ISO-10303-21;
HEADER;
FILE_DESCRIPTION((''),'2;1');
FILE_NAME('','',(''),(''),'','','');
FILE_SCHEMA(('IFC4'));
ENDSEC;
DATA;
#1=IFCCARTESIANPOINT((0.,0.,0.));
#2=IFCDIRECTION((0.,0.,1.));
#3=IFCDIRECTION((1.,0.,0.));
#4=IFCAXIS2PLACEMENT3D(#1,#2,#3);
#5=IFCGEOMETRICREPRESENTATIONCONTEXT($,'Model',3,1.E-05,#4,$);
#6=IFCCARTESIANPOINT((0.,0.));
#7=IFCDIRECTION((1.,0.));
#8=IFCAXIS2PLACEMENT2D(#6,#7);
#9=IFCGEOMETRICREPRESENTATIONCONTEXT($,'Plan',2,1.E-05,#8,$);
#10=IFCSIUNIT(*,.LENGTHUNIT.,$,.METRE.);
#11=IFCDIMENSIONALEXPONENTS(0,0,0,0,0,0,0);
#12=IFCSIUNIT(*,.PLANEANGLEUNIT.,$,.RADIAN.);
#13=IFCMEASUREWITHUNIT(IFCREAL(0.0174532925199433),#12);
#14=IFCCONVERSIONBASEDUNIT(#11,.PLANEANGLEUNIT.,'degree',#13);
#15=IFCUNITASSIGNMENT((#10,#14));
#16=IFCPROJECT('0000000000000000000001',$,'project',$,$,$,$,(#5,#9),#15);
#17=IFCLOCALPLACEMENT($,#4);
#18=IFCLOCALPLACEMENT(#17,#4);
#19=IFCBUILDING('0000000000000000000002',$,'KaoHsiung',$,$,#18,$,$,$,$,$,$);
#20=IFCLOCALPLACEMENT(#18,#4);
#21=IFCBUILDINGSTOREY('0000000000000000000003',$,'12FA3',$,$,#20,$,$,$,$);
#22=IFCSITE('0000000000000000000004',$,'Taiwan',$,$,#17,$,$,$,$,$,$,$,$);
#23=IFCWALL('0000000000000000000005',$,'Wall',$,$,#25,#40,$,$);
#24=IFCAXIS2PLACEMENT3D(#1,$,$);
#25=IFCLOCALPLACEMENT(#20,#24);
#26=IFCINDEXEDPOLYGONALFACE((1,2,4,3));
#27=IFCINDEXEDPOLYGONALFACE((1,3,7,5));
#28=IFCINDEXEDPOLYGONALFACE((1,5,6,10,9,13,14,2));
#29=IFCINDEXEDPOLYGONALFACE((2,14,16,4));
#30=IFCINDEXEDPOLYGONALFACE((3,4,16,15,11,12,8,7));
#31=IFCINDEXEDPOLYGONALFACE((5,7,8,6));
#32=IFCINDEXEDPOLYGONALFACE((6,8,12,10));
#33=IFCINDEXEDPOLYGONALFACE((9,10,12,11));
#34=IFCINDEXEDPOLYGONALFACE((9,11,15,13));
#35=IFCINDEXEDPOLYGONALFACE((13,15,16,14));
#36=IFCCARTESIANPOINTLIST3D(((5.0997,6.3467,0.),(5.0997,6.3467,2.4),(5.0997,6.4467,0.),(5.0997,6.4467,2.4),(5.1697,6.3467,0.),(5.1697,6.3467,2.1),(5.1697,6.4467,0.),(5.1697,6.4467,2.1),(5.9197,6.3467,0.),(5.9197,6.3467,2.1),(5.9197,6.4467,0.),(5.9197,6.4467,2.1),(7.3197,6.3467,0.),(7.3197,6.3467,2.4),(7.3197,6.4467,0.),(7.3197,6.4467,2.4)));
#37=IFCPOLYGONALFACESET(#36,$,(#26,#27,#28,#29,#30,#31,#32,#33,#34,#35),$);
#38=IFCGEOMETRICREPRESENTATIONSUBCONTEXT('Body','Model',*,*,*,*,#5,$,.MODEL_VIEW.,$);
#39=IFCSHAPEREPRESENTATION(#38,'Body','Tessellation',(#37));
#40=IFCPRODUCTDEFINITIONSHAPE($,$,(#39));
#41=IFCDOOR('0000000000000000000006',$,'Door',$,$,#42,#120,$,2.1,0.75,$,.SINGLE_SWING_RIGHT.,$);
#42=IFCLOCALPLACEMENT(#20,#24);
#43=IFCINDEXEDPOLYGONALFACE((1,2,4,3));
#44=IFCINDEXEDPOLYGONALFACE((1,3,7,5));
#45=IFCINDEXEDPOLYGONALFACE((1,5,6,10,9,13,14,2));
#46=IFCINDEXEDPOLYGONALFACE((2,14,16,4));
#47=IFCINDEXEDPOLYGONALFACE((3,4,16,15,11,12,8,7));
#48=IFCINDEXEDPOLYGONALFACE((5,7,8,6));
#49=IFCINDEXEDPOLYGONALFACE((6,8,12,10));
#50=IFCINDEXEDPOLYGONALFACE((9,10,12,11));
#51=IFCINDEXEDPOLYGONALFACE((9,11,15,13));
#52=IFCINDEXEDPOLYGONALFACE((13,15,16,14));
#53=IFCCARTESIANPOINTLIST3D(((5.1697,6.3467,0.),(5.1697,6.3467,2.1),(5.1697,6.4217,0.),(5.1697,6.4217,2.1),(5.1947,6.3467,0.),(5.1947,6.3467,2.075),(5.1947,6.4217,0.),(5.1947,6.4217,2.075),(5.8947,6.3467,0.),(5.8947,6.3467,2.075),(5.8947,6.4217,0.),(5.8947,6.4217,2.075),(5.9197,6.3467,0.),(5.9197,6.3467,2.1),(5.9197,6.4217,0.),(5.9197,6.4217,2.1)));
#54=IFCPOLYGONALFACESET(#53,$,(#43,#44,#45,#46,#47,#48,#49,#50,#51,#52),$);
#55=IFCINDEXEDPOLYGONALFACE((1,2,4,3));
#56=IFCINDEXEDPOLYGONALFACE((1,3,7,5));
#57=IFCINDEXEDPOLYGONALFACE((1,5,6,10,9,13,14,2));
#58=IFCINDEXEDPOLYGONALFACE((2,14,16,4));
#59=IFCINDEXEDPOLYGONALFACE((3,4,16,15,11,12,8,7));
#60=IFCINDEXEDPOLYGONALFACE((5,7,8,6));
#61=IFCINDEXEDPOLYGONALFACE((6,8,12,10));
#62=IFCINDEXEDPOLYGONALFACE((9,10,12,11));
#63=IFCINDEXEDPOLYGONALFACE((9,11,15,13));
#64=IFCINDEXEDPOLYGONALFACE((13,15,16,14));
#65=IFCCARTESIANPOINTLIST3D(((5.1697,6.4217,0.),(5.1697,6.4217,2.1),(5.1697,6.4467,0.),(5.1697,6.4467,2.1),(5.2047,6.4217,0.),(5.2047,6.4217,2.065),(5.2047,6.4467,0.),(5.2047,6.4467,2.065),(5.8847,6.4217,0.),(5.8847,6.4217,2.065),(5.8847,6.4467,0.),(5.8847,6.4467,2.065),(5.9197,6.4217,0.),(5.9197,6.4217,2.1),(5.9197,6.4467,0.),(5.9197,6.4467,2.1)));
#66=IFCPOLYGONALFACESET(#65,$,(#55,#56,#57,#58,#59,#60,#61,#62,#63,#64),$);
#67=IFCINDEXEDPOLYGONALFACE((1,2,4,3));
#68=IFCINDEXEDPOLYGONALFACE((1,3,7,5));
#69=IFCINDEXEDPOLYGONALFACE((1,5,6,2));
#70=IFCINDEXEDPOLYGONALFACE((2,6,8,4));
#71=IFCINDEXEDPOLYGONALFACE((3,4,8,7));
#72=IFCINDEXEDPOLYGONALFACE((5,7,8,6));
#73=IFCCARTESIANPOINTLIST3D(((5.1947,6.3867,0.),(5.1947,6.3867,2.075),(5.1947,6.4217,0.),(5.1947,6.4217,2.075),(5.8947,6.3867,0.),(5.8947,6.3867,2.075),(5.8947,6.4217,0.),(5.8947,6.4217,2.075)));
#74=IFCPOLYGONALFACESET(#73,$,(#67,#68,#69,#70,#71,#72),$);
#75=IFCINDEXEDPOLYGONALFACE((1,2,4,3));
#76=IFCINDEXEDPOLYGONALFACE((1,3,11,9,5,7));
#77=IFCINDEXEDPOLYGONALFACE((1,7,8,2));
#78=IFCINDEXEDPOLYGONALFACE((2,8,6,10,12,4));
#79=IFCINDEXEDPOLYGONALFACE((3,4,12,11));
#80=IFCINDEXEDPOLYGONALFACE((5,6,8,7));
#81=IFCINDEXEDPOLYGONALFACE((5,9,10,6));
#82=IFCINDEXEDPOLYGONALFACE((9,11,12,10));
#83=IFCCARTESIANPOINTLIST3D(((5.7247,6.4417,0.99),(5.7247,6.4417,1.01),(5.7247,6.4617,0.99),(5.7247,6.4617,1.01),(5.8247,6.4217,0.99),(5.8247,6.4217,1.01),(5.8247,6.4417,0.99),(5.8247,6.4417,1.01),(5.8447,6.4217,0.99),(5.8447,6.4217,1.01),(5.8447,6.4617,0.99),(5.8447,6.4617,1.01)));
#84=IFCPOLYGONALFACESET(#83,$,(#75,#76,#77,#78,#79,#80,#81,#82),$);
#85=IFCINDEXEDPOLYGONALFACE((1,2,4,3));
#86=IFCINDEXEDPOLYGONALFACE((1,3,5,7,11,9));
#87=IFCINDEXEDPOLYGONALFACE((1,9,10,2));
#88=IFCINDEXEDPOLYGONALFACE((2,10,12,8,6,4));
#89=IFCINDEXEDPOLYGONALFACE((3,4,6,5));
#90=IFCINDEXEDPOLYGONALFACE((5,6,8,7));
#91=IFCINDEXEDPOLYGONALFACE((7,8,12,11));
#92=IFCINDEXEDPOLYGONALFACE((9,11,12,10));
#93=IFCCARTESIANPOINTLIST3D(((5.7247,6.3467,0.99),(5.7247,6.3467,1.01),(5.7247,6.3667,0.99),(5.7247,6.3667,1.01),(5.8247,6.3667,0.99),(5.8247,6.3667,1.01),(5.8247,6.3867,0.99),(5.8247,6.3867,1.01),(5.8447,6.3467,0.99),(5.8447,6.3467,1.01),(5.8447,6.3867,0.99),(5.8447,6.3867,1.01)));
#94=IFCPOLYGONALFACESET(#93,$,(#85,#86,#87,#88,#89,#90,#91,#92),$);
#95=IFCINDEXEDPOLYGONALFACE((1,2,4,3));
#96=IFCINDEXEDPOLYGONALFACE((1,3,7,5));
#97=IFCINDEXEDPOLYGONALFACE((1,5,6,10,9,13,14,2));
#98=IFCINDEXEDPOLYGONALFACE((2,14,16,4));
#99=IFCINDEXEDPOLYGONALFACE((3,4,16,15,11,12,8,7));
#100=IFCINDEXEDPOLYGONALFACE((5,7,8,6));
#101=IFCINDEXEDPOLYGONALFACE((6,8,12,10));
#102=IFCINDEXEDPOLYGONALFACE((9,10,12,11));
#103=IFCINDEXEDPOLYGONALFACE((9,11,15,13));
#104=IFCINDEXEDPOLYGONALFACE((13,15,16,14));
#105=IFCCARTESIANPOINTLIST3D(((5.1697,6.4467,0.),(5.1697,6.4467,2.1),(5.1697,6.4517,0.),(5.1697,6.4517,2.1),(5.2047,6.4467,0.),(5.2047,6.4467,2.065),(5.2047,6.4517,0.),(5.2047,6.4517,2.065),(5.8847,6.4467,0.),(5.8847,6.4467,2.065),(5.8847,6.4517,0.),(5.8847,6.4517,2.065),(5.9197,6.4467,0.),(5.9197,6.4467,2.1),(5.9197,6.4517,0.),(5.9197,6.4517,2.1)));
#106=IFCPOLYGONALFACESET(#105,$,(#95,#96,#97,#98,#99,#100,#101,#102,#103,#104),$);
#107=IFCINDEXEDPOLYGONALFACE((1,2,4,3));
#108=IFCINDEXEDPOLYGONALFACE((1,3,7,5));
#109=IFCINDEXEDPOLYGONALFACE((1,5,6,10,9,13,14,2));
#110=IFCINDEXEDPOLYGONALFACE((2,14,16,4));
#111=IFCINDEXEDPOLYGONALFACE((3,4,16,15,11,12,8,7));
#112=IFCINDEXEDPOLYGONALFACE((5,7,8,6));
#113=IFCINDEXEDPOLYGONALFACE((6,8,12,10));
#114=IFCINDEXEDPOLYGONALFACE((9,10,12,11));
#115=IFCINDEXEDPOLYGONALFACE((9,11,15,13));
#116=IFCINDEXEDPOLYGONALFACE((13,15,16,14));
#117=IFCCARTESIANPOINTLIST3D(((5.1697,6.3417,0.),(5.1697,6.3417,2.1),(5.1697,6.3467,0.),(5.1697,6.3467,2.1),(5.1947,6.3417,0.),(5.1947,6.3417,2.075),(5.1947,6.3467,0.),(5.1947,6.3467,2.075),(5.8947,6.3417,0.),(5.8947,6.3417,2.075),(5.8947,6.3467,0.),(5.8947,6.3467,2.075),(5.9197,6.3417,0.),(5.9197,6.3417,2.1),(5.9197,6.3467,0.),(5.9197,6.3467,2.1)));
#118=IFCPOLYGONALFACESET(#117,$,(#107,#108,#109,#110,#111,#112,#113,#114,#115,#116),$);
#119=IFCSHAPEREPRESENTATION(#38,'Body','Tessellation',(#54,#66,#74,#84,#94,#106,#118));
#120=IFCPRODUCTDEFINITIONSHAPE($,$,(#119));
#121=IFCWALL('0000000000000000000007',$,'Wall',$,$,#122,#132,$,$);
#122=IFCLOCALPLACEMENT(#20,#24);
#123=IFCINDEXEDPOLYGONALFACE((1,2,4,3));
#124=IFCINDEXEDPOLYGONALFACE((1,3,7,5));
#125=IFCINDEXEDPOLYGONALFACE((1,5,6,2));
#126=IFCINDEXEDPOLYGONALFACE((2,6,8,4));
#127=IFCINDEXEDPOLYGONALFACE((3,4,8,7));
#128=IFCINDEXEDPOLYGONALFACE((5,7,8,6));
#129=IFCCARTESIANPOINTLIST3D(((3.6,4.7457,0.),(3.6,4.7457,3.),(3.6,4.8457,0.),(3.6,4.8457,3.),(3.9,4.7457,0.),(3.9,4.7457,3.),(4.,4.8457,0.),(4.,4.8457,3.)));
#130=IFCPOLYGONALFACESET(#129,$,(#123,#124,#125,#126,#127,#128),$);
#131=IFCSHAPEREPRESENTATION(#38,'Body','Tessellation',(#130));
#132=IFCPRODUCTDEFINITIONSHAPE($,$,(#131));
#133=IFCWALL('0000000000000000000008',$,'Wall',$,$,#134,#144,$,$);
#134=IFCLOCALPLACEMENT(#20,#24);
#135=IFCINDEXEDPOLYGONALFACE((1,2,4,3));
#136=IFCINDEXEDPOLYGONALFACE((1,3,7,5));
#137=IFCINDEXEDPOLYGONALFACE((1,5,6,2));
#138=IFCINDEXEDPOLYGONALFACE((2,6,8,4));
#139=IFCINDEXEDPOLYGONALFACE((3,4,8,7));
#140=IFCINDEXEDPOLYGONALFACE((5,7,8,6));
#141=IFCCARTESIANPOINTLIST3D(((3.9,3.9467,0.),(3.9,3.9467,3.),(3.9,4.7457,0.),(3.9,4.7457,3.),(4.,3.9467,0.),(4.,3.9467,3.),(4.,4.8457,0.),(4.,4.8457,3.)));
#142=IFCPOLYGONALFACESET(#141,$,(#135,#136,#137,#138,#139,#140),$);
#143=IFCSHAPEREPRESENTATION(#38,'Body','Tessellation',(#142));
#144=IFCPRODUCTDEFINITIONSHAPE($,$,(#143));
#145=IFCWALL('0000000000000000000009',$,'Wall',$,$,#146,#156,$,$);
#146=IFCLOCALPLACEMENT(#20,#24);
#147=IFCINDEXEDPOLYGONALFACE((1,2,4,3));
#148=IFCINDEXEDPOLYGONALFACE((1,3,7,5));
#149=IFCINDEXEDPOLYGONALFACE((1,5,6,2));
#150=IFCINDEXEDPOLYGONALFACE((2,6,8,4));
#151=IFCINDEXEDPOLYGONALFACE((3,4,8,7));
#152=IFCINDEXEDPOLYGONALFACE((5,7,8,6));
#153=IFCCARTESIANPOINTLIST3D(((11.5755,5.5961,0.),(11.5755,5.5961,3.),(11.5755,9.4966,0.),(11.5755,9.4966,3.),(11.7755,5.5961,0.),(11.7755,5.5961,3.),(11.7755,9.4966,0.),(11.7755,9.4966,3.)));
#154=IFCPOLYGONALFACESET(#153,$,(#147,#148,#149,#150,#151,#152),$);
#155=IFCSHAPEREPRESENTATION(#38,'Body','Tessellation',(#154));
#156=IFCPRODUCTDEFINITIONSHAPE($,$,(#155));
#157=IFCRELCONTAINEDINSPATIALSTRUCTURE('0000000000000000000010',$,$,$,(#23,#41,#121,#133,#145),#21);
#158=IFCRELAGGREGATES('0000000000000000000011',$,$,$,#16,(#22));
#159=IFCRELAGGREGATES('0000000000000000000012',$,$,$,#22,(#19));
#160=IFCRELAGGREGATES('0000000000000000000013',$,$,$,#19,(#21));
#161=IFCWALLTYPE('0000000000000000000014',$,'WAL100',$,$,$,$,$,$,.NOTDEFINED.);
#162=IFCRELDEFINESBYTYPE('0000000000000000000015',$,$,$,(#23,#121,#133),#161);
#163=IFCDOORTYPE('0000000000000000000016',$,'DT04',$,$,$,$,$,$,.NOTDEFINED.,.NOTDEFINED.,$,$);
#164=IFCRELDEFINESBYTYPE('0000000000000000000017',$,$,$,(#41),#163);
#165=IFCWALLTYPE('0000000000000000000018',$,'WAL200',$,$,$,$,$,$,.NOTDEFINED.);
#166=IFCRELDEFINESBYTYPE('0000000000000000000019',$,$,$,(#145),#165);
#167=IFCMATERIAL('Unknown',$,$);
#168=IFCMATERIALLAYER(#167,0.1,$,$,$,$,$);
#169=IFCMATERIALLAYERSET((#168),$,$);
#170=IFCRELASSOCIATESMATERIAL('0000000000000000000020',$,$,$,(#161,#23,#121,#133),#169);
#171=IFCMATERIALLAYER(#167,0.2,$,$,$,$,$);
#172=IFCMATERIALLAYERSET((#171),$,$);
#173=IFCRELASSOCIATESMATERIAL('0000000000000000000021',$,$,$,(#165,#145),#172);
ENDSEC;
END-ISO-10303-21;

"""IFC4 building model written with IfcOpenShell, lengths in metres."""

from ifc_helpers import new_model, entity, si_unit, converted_unit, frame, origin_with_axes, origin_2d_with_axis, place, context, subcontext, project, spatial, line, indexed_curve, outline, extrude, shape, source, transform, mapped, material, layer, layer_set, layer_usage, type_object, type_shapes, element, fill, save


model = new_model("IFC4")

# Units and contexts
model_context = context("Model", 3, precision=1e-05, world=origin_with_axes())
plan_context = context("Plan", 2, precision=1e-05, world=origin_2d_with_axis())
body_context_1 = subcontext(model_context, "Body", "Model", "MODEL_VIEW")
body_context_2 = subcontext(plan_context, "Body", "Plan", "PLAN_VIEW")
ifc_project = project(units=[si_unit("LENGTHUNIT", "METRE"), converted_unit("PLANEANGLEUNIT", "degree", entity("IfcReal", 0.0174532925199433), si_unit("PLANEANGLEUNIT", "RADIAN"), dimensions=[0, 0, 0, 0, 0, 0, 0])], contexts=[model_context, plan_context])

# Site, building, storey
site_placement = place(None, origin_with_axes())
site = spatial("IfcSite", under=ifc_project, at=site_placement, Name="Taiwan")
building_placement = place(site_placement, origin_with_axes())
building = spatial("IfcBuilding", under=site, at=building_placement, Name="KaoHsiung")
storey_placement = place(building_placement, origin_with_axes())
storey = spatial("IfcBuildingStorey", under=building, at=storey_placement, Name="12FA3")

# Shared definitions
ifc_material = material(Name="Unknown")

# Shared definitions
ifc_layer_1 = layer(ifc_material, 0.1)
ifc_layer_set_1 = layer_set([ifc_layer_1])
wall_type_1 = type_object("IfcWallType", Name="WAL100", PredefinedType="NOTDEFINED", material=ifc_layer_set_1)

# Wall, opening, door
ifc_layer_usage_1 = layer_usage(ifc_layer_set_1, "AXIS2", "POSITIVE", 0.0)
wall_1_placement = place(storey_placement, frame((7.3197, 6.4467, 0.0), z_axis=(0.0, 0.0, 1.0), x_axis=(-1.0, 0.0, 0.0)))
wall_1 = element("IfcWall", 1, at=wall_1_placement, inside=storey, type_object=wall_type_1, material=ifc_layer_usage_1, Name="Wall", context=body_context_1, shape_type="SweptSolid", body=[
    extrude(outline(indexed_curve([(0.0, 0.0), (0.0, 0.1), (2.22, 0.1), (2.22, 0.0)], segments=[line(1, 2, 3, 4, 1)])), origin_with_axes(), (0.0, 0.0, 1.0), 2.4),
])
shared_shape_1 = source(origin_with_axes(), body_context_1, "Body", "SweptSolid", [
    extrude(outline(indexed_curve([(0.0, 0.0), (0.75, 0.0), (0.75, 2.1), (0.0, 2.1)], segments=[line(1, 2, 3, 4, 1)])), frame((0.0, -0.6, 0.0), z_axis=(0.0, -1.0, 0.0), x_axis=(1.0, 0.0, 0.0)), (0.0, 0.0, -1.0), 1.2),
])
opening_1_placement = place(wall_1_placement, frame((1.4, 0.0, 0.0), z_axis=(0.0, 0.0, 1.0), x_axis=(1.0, 0.0, 0.0)))
opening_1 = element("IfcOpeningElement", 2, at=opening_1_placement, cuts=wall_1, PredefinedType="OPENING", context=body_context_1, shape_type="MappedRepresentation", body=[
    mapped(shared_shape_1, transform((0.0, 0.0, 0.0), x_axis=(1.0, 0.0, 0.0), y_axis=(0.0, 1.0, 0.0), z_axis=(0.0, 0.0, 1.0), scale=1.0)),
])
door_type_1 = type_object("IfcDoorType", Name="DT04", OperationType="NOTDEFINED", PredefinedType="NOTDEFINED")
shared_shape_2 = source(origin_with_axes(), body_context_1, "Body", "SweptSolid", [
    extrude(outline(indexed_curve([(0.0, 0.0), (0.0, 2.1), (0.75, 2.1), (0.75, 0.0), (0.725, 0.0), (0.725, 2.075), (0.025, 2.075), (0.025, 0.0)], segments=[line(1, 2, 3, 4, 5, 6, 7, 8, 1)])), frame((0.0, 0.025, 0.0), z_axis=(0.0, -1.0, 0.0), x_axis=(1.0, 0.0, 0.0)), (0.0, 0.0, -1.0), 0.075),
    extrude(outline(indexed_curve([(0.0, 0.0), (0.0, 2.1), (0.75, 2.1), (0.75, 0.0), (0.715, 0.0), (0.715, 2.065), (0.035, 2.065), (0.035, 0.0)], segments=[line(1, 2, 3, 4, 5, 6, 7, 8, 1)])), frame((0.0, 0.0, 0.0), z_axis=(0.0, -1.0, 0.0), x_axis=(1.0, 0.0, 0.0)), (0.0, 0.0, -1.0), 0.025),
    extrude(outline(indexed_curve([(0.0, 0.0), (0.7, 0.0), (0.7, 0.035), (0.0, 0.035)], segments=[line(1, 2, 3, 4, 1)])), frame((0.025, 0.025, 0.0), z_axis=(0.0, 0.0, 1.0), x_axis=(1.0, 0.0, 0.0)), (0.0, 0.0, 1.0), 2.075),
    extrude(outline(indexed_curve([(0.0, 0.0), (0.0, -0.04), (0.12, -0.04), (0.12, -0.02), (0.02, -0.02), (0.02, 0.0)], segments=[line(1, 2, 3, 4, 5, 6, 1)])), frame((0.075, 0.025, 0.99), z_axis=(0.0, 0.0, 1.0), x_axis=(1.0, 0.0, 0.0)), (0.0, 0.0, 1.0), 0.02),
    extrude(outline(indexed_curve([(0.0, 0.0), (0.0, 0.04), (0.12, 0.04), (0.12, 0.02), (0.02, 0.02), (0.02, 0.0)], segments=[line(1, 2, 3, 4, 5, 6, 1)])), frame((0.075, 0.06, 0.99), z_axis=(0.0, 0.0, 1.0), x_axis=(1.0, 0.0, 0.0)), (0.0, 0.0, 1.0), 0.02),
    extrude(outline(indexed_curve([(0.0, 0.0), (0.0, 2.1), (0.75, 2.1), (0.75, 0.0), (0.715, 0.0), (0.715, 2.065), (0.035, 2.065), (0.035, 0.0)], segments=[line(1, 2, 3, 4, 5, 6, 7, 8, 1)])), frame((0.0, -0.005, 0.0), z_axis=(0.0, -1.0, 0.0), x_axis=(1.0, 0.0, 0.0)), (0.0, 0.0, -1.0), 0.005),
    extrude(outline(indexed_curve([(0.0, 0.0), (0.0, 2.1), (0.75, 2.1), (0.75, 0.0), (0.725, 0.0), (0.725, 2.075), (0.025, 2.075), (0.025, 0.0)], segments=[line(1, 2, 3, 4, 5, 6, 7, 8, 1)])), frame((0.0, 0.1, 0.0), z_axis=(0.0, -1.0, 0.0), x_axis=(1.0, 0.0, 0.0)), (0.0, 0.0, -1.0), 0.005),
])
shared_shape_3 = source(origin_with_axes(), body_context_2, "Body", "Curve2D", [
    entity("IfcIndexedPolyCurve", entity("IfcCartesianPointList2D", [[0.0, 0.0], [0.0, 0.1], [0.025, 0.1], [0.025, 0.025], [0.035, 0.025], [0.035, 0.0]]), [entity("IfcLineIndex", [1, 2, 3, 4, 5, 6, 1])]),
    entity("IfcIndexedPolyCurve", entity("IfcCartesianPointList2D", [[0.75, 0.0], [0.75, 0.1], [0.725, 0.1], [0.725, 0.025], [0.715, 0.025], [0.715, 0.0]]), [entity("IfcLineIndex", [1, 2, 3, 4, 5, 6, 1])]),
    entity("IfcTrimmedCurve", entity("IfcEllipse", entity("IfcAxis2Placement2D", entity("IfcCartesianPoint", [0.69, 0.1]), entity("IfcDirection", [1.0, 0.0])), 0.665, 0.7), [entity("IfcCartesianPoint", [0.69, 0.8])], [entity("IfcCartesianPoint", [0.025, 0.1])], True, "CARTESIAN"),
    entity("IfcIndexedPolyCurve", entity("IfcCartesianPointList2D", [[0.725, 0.1], [0.69, 0.1], [0.69, 0.8], [0.725, 0.8]]), [entity("IfcLineIndex", [1, 2, 3, 4, 1])]),
])
type_shapes(door_type_1, [shared_shape_2, shared_shape_3])
door_1_placement = place(opening_1_placement, frame((0.0, 0.0, 0.0), z_axis=(0.0, 0.0, 1.0), x_axis=(1.0, 0.0, 0.0)))
door_1 = element("IfcDoor", 3, at=door_1_placement, inside=storey, type_object=door_type_1, Name="Door", OperationType="SINGLE_SWING_RIGHT", OverallHeight=2.1, OverallWidth=0.75, shapes=[
    shape(body_context_1, "Body", "MappedRepresentation", [mapped(shared_shape_2, transform((0.0, 0.0, 0.0), x_axis=(1.0, 0.0, 0.0), y_axis=(0.0, 1.0, 0.0), z_axis=(0.0, 0.0, 1.0), scale=1.0))]),
    shape(body_context_2, "Body", "MappedRepresentation", [mapped(shared_shape_3, transform((0.0, 0.0, 0.0), x_axis=(1.0, 0.0, 0.0), y_axis=(0.0, 1.0, 0.0), z_axis=(0.0, 0.0, 1.0), scale=1.0))]),
])
fill(opening_1, door_1)

# Walls
ifc_layer_usage_2 = layer_usage(ifc_layer_set_1, "AXIS2", "POSITIVE", 0.0)
wall_2_placement = place(storey_placement, frame((3.6, 4.7457, 0.0), z_axis=(0.0, 0.0, 1.0), x_axis=(1.0, 0.0, 0.0)))
element("IfcWall", 4, at=wall_2_placement, inside=storey, type_object=wall_type_1, material=ifc_layer_usage_2, Name="Wall", context=body_context_1, shape_type="SweptSolid", body=[
    extrude(outline(indexed_curve([(0.0, 0.0), (0.0, 0.1), (0.4, 0.1), (0.3, 0.0)], segments=[line(1, 2, 3, 4, 1)])), origin_with_axes(), (0.0, 0.0, 1.0), 3.0),
])
ifc_layer_usage_3 = layer_usage(ifc_layer_set_1, "AXIS2", "POSITIVE", 0.0)
wall_3_placement = place(storey_placement, frame((3.9, 4.7457, 0.0), z_axis=(0.0, 0.0, 1.0), x_axis=(0.0, -1.0, 0.0)))
element("IfcWall", 5, at=wall_3_placement, inside=storey, type_object=wall_type_1, material=ifc_layer_usage_3, Name="Wall", context=body_context_1, shape_type="SweptSolid", body=[
    extrude(outline(indexed_curve([(0.0, 0.0), (-0.1, 0.1), (0.799, 0.1), (0.799, 0.0)], segments=[line(1, 2, 3, 4, 1)])), origin_with_axes(), (0.0, 0.0, 1.0), 3.0),
])
ifc_layer_2 = layer(ifc_material, 0.2)
ifc_layer_set_2 = layer_set([ifc_layer_2])
ifc_layer_usage_4 = layer_usage(ifc_layer_set_2, "AXIS2", "POSITIVE", 0.0)
wall_type_2 = type_object("IfcWallType", Name="WAL200", PredefinedType="NOTDEFINED", material=ifc_layer_set_2)
wall_4_placement = place(storey_placement, frame((11.7755, 5.5961, 0.0), z_axis=(0.0, 0.0, 1.0), x_axis=(0.0, 1.0, 0.0)))
element("IfcWall", 6, at=wall_4_placement, inside=storey, type_object=wall_type_2, material=ifc_layer_usage_4, Name="Wall", context=body_context_1, shape_type="SweptSolid", body=[
    extrude(outline(indexed_curve([(0.0, 0.0), (0.0, 0.2), (3.9005, 0.2), (3.9005, 0.0)], segments=[line(1, 2, 3, 4, 1)])), origin_with_axes(), (0.0, 0.0, 1.0), 3.0),
])

save(model, "model.ifc")
